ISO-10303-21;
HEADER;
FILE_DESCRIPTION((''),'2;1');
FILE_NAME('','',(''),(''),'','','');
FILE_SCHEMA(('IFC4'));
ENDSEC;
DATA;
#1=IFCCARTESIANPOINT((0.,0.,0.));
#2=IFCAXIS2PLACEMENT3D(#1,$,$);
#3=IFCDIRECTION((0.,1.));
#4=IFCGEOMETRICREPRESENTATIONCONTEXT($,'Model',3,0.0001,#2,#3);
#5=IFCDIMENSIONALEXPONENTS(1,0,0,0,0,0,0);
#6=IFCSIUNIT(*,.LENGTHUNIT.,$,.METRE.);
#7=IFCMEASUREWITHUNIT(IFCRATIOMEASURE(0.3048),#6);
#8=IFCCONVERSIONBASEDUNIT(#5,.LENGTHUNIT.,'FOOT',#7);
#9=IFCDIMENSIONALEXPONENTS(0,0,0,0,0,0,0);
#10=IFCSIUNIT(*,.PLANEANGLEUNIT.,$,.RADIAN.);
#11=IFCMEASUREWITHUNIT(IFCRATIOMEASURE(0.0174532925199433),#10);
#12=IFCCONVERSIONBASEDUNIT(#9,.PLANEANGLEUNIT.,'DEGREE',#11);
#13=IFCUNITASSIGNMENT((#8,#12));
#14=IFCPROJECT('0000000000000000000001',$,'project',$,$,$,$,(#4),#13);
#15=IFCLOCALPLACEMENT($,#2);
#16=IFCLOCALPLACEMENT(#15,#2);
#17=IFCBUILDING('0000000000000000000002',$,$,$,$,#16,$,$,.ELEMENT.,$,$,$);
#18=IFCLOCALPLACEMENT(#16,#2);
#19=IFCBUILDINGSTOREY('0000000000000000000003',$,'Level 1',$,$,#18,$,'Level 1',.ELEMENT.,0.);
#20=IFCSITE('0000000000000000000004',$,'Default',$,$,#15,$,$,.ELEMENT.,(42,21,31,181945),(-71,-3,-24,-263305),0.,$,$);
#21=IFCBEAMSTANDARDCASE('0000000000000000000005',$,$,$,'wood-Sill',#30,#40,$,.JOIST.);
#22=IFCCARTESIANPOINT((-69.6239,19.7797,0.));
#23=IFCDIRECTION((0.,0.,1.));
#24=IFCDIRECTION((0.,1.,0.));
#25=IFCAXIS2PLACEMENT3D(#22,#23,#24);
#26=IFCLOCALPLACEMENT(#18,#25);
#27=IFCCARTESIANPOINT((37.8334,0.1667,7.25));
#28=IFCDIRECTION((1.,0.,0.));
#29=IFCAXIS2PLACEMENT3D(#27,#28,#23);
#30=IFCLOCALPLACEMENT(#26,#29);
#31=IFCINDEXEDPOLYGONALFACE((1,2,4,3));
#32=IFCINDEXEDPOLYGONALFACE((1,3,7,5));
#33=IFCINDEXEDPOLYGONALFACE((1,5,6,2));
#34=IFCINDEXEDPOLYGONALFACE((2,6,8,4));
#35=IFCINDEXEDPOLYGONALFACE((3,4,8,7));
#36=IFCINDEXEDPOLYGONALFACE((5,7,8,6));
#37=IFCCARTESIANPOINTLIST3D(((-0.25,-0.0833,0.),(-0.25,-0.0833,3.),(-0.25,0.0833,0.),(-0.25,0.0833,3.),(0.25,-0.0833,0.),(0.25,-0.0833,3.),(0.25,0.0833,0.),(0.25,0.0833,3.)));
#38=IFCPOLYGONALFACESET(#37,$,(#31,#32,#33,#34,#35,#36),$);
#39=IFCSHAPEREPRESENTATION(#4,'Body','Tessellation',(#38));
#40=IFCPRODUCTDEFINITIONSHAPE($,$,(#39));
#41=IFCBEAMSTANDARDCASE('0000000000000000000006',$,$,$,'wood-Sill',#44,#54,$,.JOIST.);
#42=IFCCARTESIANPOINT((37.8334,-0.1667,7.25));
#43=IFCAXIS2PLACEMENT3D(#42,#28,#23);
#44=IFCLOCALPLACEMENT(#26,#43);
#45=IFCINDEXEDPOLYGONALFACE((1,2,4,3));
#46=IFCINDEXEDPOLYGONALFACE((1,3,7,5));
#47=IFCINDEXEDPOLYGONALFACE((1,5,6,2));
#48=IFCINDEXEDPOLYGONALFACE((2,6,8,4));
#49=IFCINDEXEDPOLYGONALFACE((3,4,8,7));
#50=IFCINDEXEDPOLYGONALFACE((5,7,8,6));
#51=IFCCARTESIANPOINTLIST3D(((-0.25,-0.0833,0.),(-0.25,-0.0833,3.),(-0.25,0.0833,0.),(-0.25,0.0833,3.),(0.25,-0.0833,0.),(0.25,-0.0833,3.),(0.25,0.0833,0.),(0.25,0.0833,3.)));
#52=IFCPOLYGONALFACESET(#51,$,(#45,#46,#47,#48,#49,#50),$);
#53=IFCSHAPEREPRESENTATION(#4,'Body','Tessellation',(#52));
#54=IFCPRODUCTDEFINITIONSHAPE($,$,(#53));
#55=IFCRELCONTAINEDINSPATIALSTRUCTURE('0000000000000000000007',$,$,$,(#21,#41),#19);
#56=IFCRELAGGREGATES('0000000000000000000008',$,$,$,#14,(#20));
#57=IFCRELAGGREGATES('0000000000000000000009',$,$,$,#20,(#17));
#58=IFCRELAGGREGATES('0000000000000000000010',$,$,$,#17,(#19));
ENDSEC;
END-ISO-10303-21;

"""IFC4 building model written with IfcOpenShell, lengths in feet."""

from ifc_helpers import new_model, entity, si_unit, converted_unit, direction, frame, origin, origin_with_axes, place, context, project, spatial, rectangle, extrude, element, save


model = new_model("IFC4")

# Units and contexts
model_context = context("Model", 3, precision=0.0001, world=origin(), true_north=direction((0.0, 1.0)))
ifc_project = project(units=[converted_unit("LENGTHUNIT", "FOOT", entity("IfcRatioMeasure", 0.3048), si_unit("LENGTHUNIT", "METRE"), dimensions=[1, 0, 0, 0, 0, 0, 0]), converted_unit("PLANEANGLEUNIT", "DEGREE", entity("IfcRatioMeasure", 0.0174532925199433), si_unit("PLANEANGLEUNIT", "RADIAN"), dimensions=[0, 0, 0, 0, 0, 0, 0])], contexts=[model_context])

# Site, building, storey
site_placement = place(None, origin())
site = spatial("IfcSite", under=ifc_project, at=site_placement, Name="Default", CompositionType="ELEMENT", RefLatitude=(42, 21, 31, 181945), RefLongitude=(-71, -3, -24, -263305), RefElevation=0.0)
building_placement = place(site_placement, origin())
building = spatial("IfcBuilding", under=site, at=building_placement, CompositionType="ELEMENT")
storey_placement = place(building_placement, origin())
storey = spatial("IfcBuildingStorey", under=building, at=storey_placement, Name="Level 1", LongName="Level 1", CompositionType="ELEMENT", Elevation=0.0)

# Shared definitions
placement_1 = place(storey_placement, frame((-69.6239, 19.7797, 0.0), z_axis=(0.0, 0.0, 1.0), x_axis=(0.0, 1.0, 0.0)))

# Beams
for number, where, z_axis, x_axis in (
    (1, (37.8334, 0.1667, 7.25), (1.0, 0.0, 0.0), (0.0, 0.0, 1.0)),
    (2, (37.8334, -0.1667, 7.25), (1.0, 0.0, 0.0), (0.0, 0.0, 1.0)),
):
    element("IfcBeamStandardCase", number, at=place(placement_1, frame(where, z_axis=z_axis, x_axis=x_axis)), inside=storey, ObjectType="wood-Sill", PredefinedType="JOIST", context=model_context, shape_type="SweptSolid", body=[
        extrude(rectangle(XDim=0.5, YDim=0.1667), origin_with_axes(), (0.0, 0.0, 1.0), 3.0),
    ])

save(model, "model.ifc")
